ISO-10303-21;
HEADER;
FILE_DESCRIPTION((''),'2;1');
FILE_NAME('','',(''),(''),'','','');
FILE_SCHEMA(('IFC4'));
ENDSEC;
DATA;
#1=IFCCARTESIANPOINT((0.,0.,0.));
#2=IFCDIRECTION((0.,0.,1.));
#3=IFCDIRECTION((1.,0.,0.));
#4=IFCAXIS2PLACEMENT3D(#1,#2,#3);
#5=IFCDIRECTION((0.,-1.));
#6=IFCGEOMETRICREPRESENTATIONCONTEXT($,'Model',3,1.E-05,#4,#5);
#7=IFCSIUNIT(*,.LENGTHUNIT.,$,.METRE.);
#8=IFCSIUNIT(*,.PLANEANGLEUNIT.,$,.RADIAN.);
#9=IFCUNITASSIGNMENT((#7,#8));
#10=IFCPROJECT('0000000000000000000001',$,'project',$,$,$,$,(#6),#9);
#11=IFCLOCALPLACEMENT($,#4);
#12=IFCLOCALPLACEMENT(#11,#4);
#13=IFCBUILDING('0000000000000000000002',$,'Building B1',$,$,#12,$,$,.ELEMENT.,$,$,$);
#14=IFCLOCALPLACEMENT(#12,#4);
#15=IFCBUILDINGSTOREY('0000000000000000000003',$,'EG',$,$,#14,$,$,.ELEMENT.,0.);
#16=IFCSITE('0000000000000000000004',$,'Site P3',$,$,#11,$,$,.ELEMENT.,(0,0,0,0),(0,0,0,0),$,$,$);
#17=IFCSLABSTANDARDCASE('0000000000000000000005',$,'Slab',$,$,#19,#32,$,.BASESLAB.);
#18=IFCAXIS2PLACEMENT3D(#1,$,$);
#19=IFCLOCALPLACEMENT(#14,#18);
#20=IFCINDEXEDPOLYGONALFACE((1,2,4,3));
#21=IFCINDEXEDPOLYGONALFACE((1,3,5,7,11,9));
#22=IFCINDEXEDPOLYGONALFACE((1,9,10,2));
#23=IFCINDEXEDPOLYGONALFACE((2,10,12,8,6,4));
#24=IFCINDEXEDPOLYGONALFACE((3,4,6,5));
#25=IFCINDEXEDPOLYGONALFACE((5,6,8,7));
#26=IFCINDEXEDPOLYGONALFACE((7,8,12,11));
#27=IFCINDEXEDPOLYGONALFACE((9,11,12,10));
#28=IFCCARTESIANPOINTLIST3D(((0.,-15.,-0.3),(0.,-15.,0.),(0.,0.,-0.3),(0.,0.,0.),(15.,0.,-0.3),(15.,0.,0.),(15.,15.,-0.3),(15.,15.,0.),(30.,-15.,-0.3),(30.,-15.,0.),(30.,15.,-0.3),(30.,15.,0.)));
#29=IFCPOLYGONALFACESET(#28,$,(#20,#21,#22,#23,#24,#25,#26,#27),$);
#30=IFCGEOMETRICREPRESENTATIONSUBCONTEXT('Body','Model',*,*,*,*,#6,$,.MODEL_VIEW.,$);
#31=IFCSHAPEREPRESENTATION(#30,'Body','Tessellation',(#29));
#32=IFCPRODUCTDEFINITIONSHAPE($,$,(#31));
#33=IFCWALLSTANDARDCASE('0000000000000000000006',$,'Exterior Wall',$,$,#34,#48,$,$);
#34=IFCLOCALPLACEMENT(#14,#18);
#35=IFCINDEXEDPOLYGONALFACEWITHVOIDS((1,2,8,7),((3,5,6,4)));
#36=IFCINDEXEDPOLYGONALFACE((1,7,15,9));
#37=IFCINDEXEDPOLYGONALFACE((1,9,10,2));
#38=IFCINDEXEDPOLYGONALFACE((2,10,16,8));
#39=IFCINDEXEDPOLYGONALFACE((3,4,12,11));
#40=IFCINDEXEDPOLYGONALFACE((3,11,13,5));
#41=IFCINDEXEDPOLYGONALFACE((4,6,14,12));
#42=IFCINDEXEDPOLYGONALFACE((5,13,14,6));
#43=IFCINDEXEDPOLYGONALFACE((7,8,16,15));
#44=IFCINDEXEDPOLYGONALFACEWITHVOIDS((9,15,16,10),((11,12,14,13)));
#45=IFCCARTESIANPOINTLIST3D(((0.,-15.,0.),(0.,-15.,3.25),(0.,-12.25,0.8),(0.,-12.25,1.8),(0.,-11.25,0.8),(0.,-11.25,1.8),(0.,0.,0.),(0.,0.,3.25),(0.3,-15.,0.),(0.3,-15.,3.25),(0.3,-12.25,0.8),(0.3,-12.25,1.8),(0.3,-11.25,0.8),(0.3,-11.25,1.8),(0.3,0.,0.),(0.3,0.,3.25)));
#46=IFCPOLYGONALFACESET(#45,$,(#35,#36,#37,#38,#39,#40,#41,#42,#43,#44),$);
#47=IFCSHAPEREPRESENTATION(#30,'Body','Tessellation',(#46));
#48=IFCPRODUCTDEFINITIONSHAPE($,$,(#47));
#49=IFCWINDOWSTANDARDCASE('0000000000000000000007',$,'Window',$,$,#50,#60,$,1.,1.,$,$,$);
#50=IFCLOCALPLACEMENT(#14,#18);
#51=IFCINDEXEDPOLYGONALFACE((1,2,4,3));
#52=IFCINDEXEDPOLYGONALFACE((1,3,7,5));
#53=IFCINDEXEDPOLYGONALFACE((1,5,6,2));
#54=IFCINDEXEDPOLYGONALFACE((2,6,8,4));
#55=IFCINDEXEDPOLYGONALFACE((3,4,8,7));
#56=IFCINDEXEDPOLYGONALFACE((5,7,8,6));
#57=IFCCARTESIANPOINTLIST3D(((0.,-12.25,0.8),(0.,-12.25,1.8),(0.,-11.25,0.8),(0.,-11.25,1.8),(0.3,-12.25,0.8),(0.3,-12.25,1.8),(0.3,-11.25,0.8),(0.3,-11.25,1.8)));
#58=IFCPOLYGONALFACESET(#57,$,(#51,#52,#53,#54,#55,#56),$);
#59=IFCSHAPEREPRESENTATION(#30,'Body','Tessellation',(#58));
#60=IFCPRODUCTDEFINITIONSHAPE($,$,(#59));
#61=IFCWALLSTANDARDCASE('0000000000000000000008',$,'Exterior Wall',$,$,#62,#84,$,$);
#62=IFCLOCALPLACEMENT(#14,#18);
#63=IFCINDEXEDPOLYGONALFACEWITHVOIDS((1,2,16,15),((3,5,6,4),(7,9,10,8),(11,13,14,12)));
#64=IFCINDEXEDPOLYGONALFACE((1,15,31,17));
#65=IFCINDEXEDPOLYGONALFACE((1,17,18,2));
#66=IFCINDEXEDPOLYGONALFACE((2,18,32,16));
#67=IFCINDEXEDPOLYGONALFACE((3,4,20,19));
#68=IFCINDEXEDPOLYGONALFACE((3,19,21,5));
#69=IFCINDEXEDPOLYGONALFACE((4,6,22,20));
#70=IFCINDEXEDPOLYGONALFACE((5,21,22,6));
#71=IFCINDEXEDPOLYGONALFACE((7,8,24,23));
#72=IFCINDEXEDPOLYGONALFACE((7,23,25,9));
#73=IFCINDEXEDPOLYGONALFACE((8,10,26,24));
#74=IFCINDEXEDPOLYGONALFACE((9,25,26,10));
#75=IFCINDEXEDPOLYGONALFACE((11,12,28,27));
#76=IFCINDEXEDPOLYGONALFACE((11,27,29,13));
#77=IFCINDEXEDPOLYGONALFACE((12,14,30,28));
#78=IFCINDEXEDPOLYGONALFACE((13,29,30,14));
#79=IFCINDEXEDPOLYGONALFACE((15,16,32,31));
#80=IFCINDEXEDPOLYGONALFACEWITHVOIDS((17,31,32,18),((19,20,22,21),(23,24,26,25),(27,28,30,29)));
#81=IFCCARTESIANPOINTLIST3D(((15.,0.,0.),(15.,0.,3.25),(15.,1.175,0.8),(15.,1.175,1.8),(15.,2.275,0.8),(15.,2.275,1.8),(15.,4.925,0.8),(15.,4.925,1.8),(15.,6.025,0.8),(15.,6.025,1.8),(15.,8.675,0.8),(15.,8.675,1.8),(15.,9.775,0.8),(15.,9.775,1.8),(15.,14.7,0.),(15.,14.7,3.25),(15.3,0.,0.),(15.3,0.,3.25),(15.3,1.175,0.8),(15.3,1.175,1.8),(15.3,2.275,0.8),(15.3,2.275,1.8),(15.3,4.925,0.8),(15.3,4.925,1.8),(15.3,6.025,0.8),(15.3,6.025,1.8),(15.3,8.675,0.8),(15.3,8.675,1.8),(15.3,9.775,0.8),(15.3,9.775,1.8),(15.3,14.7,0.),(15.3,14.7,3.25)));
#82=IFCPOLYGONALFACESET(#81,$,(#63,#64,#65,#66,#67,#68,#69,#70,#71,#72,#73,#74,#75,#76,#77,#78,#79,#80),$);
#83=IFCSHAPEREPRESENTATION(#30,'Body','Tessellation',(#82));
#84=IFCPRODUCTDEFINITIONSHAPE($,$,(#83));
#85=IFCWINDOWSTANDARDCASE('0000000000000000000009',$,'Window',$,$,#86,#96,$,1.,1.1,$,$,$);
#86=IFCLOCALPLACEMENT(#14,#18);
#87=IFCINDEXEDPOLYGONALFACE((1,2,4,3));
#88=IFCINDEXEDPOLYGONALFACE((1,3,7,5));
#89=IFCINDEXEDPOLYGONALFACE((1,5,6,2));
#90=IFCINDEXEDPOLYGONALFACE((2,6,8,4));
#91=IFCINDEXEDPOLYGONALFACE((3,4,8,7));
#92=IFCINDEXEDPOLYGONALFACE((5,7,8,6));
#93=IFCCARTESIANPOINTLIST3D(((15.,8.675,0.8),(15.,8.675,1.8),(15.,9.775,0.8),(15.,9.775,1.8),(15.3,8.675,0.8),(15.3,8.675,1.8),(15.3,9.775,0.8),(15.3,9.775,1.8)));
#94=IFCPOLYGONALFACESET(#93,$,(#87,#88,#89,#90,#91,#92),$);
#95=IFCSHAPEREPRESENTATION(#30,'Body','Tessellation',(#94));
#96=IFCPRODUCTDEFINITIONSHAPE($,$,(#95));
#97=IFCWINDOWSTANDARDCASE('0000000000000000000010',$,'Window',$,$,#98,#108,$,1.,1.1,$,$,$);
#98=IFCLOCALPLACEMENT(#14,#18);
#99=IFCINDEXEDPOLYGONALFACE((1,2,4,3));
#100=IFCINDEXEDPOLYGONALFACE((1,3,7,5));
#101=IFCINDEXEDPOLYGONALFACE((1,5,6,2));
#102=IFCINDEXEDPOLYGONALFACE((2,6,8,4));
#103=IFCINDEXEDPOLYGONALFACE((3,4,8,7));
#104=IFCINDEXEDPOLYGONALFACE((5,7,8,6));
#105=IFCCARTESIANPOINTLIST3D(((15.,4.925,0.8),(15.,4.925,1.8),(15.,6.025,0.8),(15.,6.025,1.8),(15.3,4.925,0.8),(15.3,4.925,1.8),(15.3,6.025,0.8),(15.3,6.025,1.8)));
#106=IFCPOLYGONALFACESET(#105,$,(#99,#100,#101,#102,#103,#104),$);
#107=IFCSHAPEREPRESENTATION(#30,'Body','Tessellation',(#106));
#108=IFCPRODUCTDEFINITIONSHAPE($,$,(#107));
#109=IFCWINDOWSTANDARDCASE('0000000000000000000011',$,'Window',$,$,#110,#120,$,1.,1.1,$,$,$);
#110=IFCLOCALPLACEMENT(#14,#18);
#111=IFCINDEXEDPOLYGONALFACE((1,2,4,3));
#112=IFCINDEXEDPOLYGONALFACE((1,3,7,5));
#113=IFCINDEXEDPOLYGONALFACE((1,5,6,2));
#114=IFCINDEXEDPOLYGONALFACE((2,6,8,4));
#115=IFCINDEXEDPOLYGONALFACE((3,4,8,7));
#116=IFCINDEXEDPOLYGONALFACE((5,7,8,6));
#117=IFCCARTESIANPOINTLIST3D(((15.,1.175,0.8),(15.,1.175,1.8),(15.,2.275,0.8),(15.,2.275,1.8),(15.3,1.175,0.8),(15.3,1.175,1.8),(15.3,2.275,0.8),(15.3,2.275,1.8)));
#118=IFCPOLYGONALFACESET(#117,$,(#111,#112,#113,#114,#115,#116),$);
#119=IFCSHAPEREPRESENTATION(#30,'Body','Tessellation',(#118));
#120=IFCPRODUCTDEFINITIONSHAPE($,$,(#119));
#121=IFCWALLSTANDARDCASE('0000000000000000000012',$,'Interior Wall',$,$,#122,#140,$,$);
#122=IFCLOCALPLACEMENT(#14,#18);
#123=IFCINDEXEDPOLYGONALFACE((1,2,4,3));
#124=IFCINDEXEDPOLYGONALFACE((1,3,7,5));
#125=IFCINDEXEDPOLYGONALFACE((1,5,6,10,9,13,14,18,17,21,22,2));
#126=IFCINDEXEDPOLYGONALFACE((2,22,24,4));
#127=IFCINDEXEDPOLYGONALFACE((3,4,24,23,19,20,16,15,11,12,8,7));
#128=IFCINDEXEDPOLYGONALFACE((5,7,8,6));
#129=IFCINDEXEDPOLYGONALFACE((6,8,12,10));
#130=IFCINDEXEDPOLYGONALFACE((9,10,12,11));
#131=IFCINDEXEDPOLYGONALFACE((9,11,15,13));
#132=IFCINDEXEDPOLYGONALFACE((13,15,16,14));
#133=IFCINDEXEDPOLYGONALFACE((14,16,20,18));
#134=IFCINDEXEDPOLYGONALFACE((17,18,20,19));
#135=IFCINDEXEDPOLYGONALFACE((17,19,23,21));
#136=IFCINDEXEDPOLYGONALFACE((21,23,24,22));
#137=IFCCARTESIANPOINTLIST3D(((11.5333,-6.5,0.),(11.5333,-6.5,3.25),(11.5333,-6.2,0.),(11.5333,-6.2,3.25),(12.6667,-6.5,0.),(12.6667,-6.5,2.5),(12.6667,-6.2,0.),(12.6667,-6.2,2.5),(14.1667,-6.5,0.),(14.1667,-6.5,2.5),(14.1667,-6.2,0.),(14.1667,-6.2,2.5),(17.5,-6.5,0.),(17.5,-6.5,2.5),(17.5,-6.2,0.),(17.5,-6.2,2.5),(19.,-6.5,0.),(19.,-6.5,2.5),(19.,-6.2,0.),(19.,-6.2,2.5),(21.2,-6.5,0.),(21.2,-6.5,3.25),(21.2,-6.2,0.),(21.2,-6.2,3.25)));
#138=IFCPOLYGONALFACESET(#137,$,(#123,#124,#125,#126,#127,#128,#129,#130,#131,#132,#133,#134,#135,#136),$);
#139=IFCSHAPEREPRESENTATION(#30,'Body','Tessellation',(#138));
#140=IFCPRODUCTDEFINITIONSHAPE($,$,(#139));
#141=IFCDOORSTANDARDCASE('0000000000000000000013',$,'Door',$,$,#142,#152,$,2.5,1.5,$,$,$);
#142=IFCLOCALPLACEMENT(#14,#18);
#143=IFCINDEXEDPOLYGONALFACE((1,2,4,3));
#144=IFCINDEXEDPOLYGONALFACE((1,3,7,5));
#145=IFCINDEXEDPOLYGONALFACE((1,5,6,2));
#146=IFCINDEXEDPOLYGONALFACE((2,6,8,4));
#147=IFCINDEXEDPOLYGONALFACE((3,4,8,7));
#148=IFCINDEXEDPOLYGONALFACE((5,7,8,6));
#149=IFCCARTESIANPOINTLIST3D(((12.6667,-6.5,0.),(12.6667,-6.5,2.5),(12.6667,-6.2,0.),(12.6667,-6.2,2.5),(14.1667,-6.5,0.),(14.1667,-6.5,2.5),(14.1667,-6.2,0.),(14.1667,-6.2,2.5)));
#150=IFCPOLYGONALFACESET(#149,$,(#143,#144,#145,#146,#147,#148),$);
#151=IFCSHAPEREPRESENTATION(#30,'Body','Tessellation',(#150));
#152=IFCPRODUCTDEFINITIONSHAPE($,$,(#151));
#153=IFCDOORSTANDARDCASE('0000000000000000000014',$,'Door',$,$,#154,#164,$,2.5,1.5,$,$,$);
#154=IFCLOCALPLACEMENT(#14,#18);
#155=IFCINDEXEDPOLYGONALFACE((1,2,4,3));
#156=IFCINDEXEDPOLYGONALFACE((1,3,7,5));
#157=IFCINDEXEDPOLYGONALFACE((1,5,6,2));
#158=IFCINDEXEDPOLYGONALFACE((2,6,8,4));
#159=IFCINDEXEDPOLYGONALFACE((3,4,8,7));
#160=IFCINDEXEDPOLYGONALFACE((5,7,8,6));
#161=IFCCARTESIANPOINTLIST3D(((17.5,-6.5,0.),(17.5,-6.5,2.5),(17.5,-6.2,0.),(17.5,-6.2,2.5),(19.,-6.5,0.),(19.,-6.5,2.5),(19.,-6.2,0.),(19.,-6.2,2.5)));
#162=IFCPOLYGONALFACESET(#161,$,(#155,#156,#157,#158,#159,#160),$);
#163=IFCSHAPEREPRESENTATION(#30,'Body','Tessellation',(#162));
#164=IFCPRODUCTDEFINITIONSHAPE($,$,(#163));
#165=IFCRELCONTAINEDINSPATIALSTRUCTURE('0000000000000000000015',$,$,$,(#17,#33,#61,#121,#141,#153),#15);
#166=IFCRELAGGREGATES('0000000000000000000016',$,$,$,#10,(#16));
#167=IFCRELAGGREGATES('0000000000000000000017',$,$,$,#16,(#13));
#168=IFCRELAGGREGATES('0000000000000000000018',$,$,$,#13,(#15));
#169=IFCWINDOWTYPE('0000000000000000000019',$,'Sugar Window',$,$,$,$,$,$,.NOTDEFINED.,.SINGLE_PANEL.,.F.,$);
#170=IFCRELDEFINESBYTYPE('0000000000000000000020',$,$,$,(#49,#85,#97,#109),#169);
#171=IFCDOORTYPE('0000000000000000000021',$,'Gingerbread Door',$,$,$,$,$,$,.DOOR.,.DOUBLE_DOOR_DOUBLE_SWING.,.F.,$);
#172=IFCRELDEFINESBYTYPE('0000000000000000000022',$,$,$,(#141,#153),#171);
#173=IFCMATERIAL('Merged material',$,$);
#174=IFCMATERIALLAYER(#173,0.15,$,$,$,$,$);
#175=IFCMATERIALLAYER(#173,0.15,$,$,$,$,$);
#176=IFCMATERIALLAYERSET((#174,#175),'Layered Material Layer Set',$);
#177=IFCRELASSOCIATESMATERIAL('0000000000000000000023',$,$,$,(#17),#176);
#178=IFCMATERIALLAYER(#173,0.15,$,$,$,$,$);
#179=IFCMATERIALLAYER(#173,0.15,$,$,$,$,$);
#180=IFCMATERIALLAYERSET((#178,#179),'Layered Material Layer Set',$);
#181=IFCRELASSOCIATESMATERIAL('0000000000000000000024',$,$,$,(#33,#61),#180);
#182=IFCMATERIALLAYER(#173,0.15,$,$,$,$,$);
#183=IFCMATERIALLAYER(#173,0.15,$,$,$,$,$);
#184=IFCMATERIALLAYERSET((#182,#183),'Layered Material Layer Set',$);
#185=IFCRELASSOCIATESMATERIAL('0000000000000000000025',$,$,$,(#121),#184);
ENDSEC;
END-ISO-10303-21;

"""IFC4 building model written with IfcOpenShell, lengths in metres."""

from ifc_helpers import new_model, si_unit, direction, frame, origin_with_axes, place, context, subcontext, project, spatial, polyline, outline, extrude, source, transform, mapped, material, layer, layer_set, layer_usage, type_object, element, fill, save


model = new_model("IFC4")

# Units and contexts
model_context = context("Model", 3, precision=1e-05, world=origin_with_axes(), true_north=direction((0.0, -1.0)))
body_context = subcontext(model_context, "Body", "Model", "MODEL_VIEW")
ifc_project = project(units=[si_unit("LENGTHUNIT", "METRE"), si_unit("PLANEANGLEUNIT", "RADIAN")], contexts=[model_context])

# Site, building, storey
site_placement = place(None, origin_with_axes())
site = spatial("IfcSite", under=ifc_project, at=site_placement, Name="Site P3", CompositionType="ELEMENT", RefLatitude=(0, 0, 0, 0), RefLongitude=(0, 0, 0, 0))
building_placement = place(site_placement, origin_with_axes())
building = spatial("IfcBuilding", under=site, at=building_placement, Name="Building B1", CompositionType="ELEMENT")
storey_placement = place(building_placement, origin_with_axes())
storey = spatial("IfcBuildingStorey", under=building, at=storey_placement, Name="EG", CompositionType="ELEMENT", Elevation=0.0)

# Slab
ifc_material = material(Name="Merged material")
ifc_layer_1 = layer(ifc_material, 0.15)
ifc_layer_2 = layer(ifc_material, 0.15)
ifc_layer_set_1 = layer_set([ifc_layer_1, ifc_layer_2], Name="Layered Material Layer Set")
ifc_layer_usage_1 = layer_usage(ifc_layer_set_1, "AXIS2", "POSITIVE", -0.15)
slab_placement = place(storey_placement, origin_with_axes())
element("IfcSlabStandardCase", 1, at=slab_placement, inside=storey, material=ifc_layer_usage_1, Name="Slab", PredefinedType="BASESLAB", context=body_context, shape_type="SweptSolid", body=[
    extrude(outline(polyline([(0.0, -15.0), (30.0, -15.0), (30.0, 15.0), (15.0, 15.0), (15.0, 0.0), (0.0, 0.0), (0.0, -15.0)])), frame((0.0, 0.0, -0.3), z_axis=(0.0, 0.0, 1.0), x_axis=(1.0, 0.0, 0.0)), (0.0, 0.0, 1.0), 0.3),
])

# Wall, opening, window
ifc_layer_3 = layer(ifc_material, 0.15)
ifc_layer_4 = layer(ifc_material, 0.15)
ifc_layer_set_2 = layer_set([ifc_layer_3, ifc_layer_4], Name="Layered Material Layer Set")
ifc_layer_usage_2 = layer_usage(ifc_layer_set_2, "AXIS2", "POSITIVE", -0.15)
wall_1_placement = place(storey_placement, frame((0.15, 0.0, 0.0), z_axis=(0.0, 0.0, 1.0), x_axis=(0.0, -1.0, 0.0)))
wall_1 = element("IfcWallStandardCase", 2, at=wall_1_placement, inside=storey, material=ifc_layer_usage_2, Name="Exterior Wall", context=body_context, shape_type="SweptSolid", body=[
    extrude(outline(polyline([(0.0, 0.15), (15.0, 0.15), (15.0, -0.15), (0.0, -0.15), (0.0, 0.15)])), origin_with_axes(), (0.0, 0.0, 1.0), 3.25),
])
opening_1_placement = place(wall_1_placement, frame((11.25, 0.0, 0.8), z_axis=(0.0, 0.0, 1.0), x_axis=(1.0, 0.0, 0.0)))
opening_1 = element("IfcOpeningStandardCase", 3, at=opening_1_placement, cuts=wall_1, context=body_context, shape_type="SweptSolid", body=[
    extrude(outline(polyline([(0.0, 0.0), (0.0, 1.0), (1.0, 1.0), (1.0, 0.0), (0.0, 0.0)])), frame((0.0, -0.15, 0.0), z_axis=(0.0, 1.0, 0.0), x_axis=(0.0, 0.0, 1.0)), (0.0, 0.0, 1.0), 0.3),
])
window_type = type_object("IfcWindowType", Name="Sugar Window", ParameterTakesPrecedence=False, PartitioningType="SINGLE_PANEL", PredefinedType="NOTDEFINED")
shared_shape_1 = source(origin_with_axes(), body_context, "Body", "SweptSolid", [
    extrude(outline(polyline([(0.0, 0.0), (0.0, 1.0), (1.0, 1.0), (1.0, 0.0), (0.0, 0.0)])), frame((0.0, -0.15, 0.0), z_axis=(0.0, 1.0, 0.0), x_axis=(0.0, 0.0, 1.0)), (0.0, 0.0, 1.0), 0.3),
])
window_1_placement = place(opening_1_placement, origin_with_axes())
window_1 = element("IfcWindowStandardCase", 4, at=window_1_placement, type_object=window_type, Name="Window", OverallHeight=1.0, OverallWidth=1.0, context=body_context, shape_type="MappedRepresentation", body=[
    mapped(shared_shape_1, transform((0.0, 0.0, 0.0))),
])
fill(opening_1, window_1)

# Wall, openings, windows
wall_2_placement = place(storey_placement, frame((15.15, 14.7, 0.0), z_axis=(0.0, 0.0, 1.0), x_axis=(0.0, -1.0, 0.0)))
wall_2 = element("IfcWallStandardCase", 5, at=wall_2_placement, inside=storey, material=ifc_layer_usage_2, Name="Exterior Wall", context=body_context, shape_type="SweptSolid", body=[
    extrude(outline(polyline([(0.0, 0.15), (14.7, 0.15), (14.7, -0.15), (0.0, -0.15), (0.0, 0.15)])), origin_with_axes(), (0.0, 0.0, 1.0), 3.25),
])
opening_2_placement = place(wall_2_placement, frame((4.925, 0.0, 0.8), z_axis=(0.0, 0.0, 1.0), x_axis=(1.0, 0.0, 0.0)))
opening_2 = element("IfcOpeningStandardCase", 6, at=opening_2_placement, cuts=wall_2, context=body_context, shape_type="SweptSolid", body=[
    extrude(outline(polyline([(0.0, 0.0), (0.0, 1.1), (1.0, 1.1), (1.0, 0.0), (0.0, 0.0)])), frame((0.0, -0.15, 0.0), z_axis=(0.0, 1.0, 0.0), x_axis=(0.0, 0.0, 1.0)), (0.0, 0.0, 1.0), 0.3),
])
opening_3_placement = place(wall_2_placement, frame((8.675, 0.0, 0.8), z_axis=(0.0, 0.0, 1.0), x_axis=(1.0, 0.0, 0.0)))
opening_3 = element("IfcOpeningStandardCase", 7, at=opening_3_placement, cuts=wall_2, context=body_context, shape_type="SweptSolid", body=[
    extrude(outline(polyline([(0.0, 0.0), (0.0, 1.1), (1.0, 1.1), (1.0, 0.0), (0.0, 0.0)])), frame((0.0, -0.15, 0.0), z_axis=(0.0, 1.0, 0.0), x_axis=(0.0, 0.0, 1.0)), (0.0, 0.0, 1.0), 0.3),
])
opening_4_placement = place(wall_2_placement, frame((12.425, 0.0, 0.8), z_axis=(0.0, 0.0, 1.0), x_axis=(1.0, 0.0, 0.0)))
opening_4 = element("IfcOpeningStandardCase", 8, at=opening_4_placement, cuts=wall_2, context=body_context, shape_type="SweptSolid", body=[
    extrude(outline(polyline([(0.0, 0.0), (0.0, 1.1), (1.0, 1.1), (1.0, 0.0), (0.0, 0.0)])), frame((0.0, -0.15, 0.0), z_axis=(0.0, 1.0, 0.0), x_axis=(0.0, 0.0, 1.0)), (0.0, 0.0, 1.0), 0.3),
])
shared_shape_2 = source(origin_with_axes(), body_context, "Body", "SweptSolid", [
    extrude(outline(polyline([(0.0, 0.0), (0.0, 1.1), (1.0, 1.1), (1.0, 0.0), (0.0, 0.0)])), frame((0.0, -0.15, 0.0), z_axis=(0.0, 1.0, 0.0), x_axis=(0.0, 0.0, 1.0)), (0.0, 0.0, 1.0), 0.3),
])
window_2_placement = place(opening_2_placement, origin_with_axes())
window_2 = element("IfcWindowStandardCase", 9, at=window_2_placement, type_object=window_type, Name="Window", OverallHeight=1.0, OverallWidth=1.1, context=body_context, shape_type="MappedRepresentation", body=[
    mapped(shared_shape_2, transform((0.0, 0.0, 0.0))),
])
fill(opening_2, window_2)
window_3_placement = place(opening_3_placement, origin_with_axes())
window_3 = element("IfcWindowStandardCase", 10, at=window_3_placement, type_object=window_type, Name="Window", OverallHeight=1.0, OverallWidth=1.1, context=body_context, shape_type="MappedRepresentation", body=[
    mapped(shared_shape_2, transform((0.0, 0.0, 0.0))),
])
fill(opening_3, window_3)
window_4_placement = place(opening_4_placement, origin_with_axes())
window_4 = element("IfcWindowStandardCase", 11, at=window_4_placement, type_object=window_type, Name="Window", OverallHeight=1.0, OverallWidth=1.1, context=body_context, shape_type="MappedRepresentation", body=[
    mapped(shared_shape_2, transform((0.0, 0.0, 0.0))),
])
fill(opening_4, window_4)

# Wall, openings, doors
ifc_layer_5 = layer(ifc_material, 0.15)
ifc_layer_6 = layer(ifc_material, 0.15)
ifc_layer_set_3 = layer_set([ifc_layer_5, ifc_layer_6], Name="Layered Material Layer Set")
ifc_layer_usage_3 = layer_usage(ifc_layer_set_3, "AXIS2", "POSITIVE", -0.15)
wall_3_placement = place(storey_placement, frame((11.5333, -6.35, 0.0), z_axis=(0.0, 0.0, 1.0), x_axis=(1.0, 0.0, 0.0)))
wall_3 = element("IfcWallStandardCase", 12, at=wall_3_placement, inside=storey, material=ifc_layer_usage_3, Name="Interior Wall", context=body_context, shape_type="SweptSolid", body=[
    extrude(outline(polyline([(0.0, 0.15), (9.6667, 0.15), (9.6667, -0.15), (0.0, -0.15), (0.0, 0.15)])), origin_with_axes(), (0.0, 0.0, 1.0), 3.25),
])
opening_5_placement = place(wall_3_placement, frame((1.1333, 0.0, 0.0), z_axis=(0.0, 0.0, 1.0), x_axis=(1.0, 0.0, 0.0)))
opening_5 = element("IfcOpeningStandardCase", 13, at=opening_5_placement, cuts=wall_3, context=body_context, shape_type="SweptSolid", body=[
    extrude(outline(polyline([(0.0, 0.0), (0.0, 1.5), (2.5, 1.5), (2.5, 0.0), (0.0, 0.0)])), frame((0.0, -0.15, 0.0), z_axis=(0.0, 1.0, 0.0), x_axis=(0.0, 0.0, 1.0)), (0.0, 0.0, 1.0), 0.3),
])
opening_6_placement = place(wall_3_placement, frame((5.9667, 0.0, 0.0), z_axis=(0.0, 0.0, 1.0), x_axis=(1.0, 0.0, 0.0)))
opening_6 = element("IfcOpeningStandardCase", 14, at=opening_6_placement, cuts=wall_3, context=body_context, shape_type="SweptSolid", body=[
    extrude(outline(polyline([(0.0, 0.0), (0.0, 1.5), (2.5, 1.5), (2.5, 0.0), (0.0, 0.0)])), frame((0.0, -0.15, 0.0), z_axis=(0.0, 1.0, 0.0), x_axis=(0.0, 0.0, 1.0)), (0.0, 0.0, 1.0), 0.3),
])
door_type = type_object("IfcDoorType", Name="Gingerbread Door", OperationType="DOUBLE_DOOR_DOUBLE_SWING", ParameterTakesPrecedence=False, PredefinedType="DOOR")
shared_shape_3 = source(origin_with_axes(), body_context, "Body", "SweptSolid", [
    extrude(outline(polyline([(0.0, 0.0), (0.0, 1.5), (2.5, 1.5), (2.5, 0.0), (0.0, 0.0)])), frame((0.0, -0.15, 0.0), z_axis=(0.0, 1.0, 0.0), x_axis=(0.0, 0.0, 1.0)), (0.0, 0.0, 1.0), 0.3),
])
door_1_placement = place(opening_5_placement, origin_with_axes())
door_1 = element("IfcDoorStandardCase", 15, at=door_1_placement, inside=storey, type_object=door_type, Name="Door", OverallHeight=2.5, OverallWidth=1.5, context=body_context, shape_type="MappedRepresentation", body=[
    mapped(shared_shape_3, transform((0.0, 0.0, 0.0))),
])
fill(opening_5, door_1)
door_2_placement = place(opening_6_placement, origin_with_axes())
door_2 = element("IfcDoorStandardCase", 16, at=door_2_placement, inside=storey, type_object=door_type, Name="Door", OverallHeight=2.5, OverallWidth=1.5, context=body_context, shape_type="MappedRepresentation", body=[
    mapped(shared_shape_3, transform((0.0, 0.0, 0.0))),
])
fill(opening_6, door_2)

save(model, "model.ifc")
